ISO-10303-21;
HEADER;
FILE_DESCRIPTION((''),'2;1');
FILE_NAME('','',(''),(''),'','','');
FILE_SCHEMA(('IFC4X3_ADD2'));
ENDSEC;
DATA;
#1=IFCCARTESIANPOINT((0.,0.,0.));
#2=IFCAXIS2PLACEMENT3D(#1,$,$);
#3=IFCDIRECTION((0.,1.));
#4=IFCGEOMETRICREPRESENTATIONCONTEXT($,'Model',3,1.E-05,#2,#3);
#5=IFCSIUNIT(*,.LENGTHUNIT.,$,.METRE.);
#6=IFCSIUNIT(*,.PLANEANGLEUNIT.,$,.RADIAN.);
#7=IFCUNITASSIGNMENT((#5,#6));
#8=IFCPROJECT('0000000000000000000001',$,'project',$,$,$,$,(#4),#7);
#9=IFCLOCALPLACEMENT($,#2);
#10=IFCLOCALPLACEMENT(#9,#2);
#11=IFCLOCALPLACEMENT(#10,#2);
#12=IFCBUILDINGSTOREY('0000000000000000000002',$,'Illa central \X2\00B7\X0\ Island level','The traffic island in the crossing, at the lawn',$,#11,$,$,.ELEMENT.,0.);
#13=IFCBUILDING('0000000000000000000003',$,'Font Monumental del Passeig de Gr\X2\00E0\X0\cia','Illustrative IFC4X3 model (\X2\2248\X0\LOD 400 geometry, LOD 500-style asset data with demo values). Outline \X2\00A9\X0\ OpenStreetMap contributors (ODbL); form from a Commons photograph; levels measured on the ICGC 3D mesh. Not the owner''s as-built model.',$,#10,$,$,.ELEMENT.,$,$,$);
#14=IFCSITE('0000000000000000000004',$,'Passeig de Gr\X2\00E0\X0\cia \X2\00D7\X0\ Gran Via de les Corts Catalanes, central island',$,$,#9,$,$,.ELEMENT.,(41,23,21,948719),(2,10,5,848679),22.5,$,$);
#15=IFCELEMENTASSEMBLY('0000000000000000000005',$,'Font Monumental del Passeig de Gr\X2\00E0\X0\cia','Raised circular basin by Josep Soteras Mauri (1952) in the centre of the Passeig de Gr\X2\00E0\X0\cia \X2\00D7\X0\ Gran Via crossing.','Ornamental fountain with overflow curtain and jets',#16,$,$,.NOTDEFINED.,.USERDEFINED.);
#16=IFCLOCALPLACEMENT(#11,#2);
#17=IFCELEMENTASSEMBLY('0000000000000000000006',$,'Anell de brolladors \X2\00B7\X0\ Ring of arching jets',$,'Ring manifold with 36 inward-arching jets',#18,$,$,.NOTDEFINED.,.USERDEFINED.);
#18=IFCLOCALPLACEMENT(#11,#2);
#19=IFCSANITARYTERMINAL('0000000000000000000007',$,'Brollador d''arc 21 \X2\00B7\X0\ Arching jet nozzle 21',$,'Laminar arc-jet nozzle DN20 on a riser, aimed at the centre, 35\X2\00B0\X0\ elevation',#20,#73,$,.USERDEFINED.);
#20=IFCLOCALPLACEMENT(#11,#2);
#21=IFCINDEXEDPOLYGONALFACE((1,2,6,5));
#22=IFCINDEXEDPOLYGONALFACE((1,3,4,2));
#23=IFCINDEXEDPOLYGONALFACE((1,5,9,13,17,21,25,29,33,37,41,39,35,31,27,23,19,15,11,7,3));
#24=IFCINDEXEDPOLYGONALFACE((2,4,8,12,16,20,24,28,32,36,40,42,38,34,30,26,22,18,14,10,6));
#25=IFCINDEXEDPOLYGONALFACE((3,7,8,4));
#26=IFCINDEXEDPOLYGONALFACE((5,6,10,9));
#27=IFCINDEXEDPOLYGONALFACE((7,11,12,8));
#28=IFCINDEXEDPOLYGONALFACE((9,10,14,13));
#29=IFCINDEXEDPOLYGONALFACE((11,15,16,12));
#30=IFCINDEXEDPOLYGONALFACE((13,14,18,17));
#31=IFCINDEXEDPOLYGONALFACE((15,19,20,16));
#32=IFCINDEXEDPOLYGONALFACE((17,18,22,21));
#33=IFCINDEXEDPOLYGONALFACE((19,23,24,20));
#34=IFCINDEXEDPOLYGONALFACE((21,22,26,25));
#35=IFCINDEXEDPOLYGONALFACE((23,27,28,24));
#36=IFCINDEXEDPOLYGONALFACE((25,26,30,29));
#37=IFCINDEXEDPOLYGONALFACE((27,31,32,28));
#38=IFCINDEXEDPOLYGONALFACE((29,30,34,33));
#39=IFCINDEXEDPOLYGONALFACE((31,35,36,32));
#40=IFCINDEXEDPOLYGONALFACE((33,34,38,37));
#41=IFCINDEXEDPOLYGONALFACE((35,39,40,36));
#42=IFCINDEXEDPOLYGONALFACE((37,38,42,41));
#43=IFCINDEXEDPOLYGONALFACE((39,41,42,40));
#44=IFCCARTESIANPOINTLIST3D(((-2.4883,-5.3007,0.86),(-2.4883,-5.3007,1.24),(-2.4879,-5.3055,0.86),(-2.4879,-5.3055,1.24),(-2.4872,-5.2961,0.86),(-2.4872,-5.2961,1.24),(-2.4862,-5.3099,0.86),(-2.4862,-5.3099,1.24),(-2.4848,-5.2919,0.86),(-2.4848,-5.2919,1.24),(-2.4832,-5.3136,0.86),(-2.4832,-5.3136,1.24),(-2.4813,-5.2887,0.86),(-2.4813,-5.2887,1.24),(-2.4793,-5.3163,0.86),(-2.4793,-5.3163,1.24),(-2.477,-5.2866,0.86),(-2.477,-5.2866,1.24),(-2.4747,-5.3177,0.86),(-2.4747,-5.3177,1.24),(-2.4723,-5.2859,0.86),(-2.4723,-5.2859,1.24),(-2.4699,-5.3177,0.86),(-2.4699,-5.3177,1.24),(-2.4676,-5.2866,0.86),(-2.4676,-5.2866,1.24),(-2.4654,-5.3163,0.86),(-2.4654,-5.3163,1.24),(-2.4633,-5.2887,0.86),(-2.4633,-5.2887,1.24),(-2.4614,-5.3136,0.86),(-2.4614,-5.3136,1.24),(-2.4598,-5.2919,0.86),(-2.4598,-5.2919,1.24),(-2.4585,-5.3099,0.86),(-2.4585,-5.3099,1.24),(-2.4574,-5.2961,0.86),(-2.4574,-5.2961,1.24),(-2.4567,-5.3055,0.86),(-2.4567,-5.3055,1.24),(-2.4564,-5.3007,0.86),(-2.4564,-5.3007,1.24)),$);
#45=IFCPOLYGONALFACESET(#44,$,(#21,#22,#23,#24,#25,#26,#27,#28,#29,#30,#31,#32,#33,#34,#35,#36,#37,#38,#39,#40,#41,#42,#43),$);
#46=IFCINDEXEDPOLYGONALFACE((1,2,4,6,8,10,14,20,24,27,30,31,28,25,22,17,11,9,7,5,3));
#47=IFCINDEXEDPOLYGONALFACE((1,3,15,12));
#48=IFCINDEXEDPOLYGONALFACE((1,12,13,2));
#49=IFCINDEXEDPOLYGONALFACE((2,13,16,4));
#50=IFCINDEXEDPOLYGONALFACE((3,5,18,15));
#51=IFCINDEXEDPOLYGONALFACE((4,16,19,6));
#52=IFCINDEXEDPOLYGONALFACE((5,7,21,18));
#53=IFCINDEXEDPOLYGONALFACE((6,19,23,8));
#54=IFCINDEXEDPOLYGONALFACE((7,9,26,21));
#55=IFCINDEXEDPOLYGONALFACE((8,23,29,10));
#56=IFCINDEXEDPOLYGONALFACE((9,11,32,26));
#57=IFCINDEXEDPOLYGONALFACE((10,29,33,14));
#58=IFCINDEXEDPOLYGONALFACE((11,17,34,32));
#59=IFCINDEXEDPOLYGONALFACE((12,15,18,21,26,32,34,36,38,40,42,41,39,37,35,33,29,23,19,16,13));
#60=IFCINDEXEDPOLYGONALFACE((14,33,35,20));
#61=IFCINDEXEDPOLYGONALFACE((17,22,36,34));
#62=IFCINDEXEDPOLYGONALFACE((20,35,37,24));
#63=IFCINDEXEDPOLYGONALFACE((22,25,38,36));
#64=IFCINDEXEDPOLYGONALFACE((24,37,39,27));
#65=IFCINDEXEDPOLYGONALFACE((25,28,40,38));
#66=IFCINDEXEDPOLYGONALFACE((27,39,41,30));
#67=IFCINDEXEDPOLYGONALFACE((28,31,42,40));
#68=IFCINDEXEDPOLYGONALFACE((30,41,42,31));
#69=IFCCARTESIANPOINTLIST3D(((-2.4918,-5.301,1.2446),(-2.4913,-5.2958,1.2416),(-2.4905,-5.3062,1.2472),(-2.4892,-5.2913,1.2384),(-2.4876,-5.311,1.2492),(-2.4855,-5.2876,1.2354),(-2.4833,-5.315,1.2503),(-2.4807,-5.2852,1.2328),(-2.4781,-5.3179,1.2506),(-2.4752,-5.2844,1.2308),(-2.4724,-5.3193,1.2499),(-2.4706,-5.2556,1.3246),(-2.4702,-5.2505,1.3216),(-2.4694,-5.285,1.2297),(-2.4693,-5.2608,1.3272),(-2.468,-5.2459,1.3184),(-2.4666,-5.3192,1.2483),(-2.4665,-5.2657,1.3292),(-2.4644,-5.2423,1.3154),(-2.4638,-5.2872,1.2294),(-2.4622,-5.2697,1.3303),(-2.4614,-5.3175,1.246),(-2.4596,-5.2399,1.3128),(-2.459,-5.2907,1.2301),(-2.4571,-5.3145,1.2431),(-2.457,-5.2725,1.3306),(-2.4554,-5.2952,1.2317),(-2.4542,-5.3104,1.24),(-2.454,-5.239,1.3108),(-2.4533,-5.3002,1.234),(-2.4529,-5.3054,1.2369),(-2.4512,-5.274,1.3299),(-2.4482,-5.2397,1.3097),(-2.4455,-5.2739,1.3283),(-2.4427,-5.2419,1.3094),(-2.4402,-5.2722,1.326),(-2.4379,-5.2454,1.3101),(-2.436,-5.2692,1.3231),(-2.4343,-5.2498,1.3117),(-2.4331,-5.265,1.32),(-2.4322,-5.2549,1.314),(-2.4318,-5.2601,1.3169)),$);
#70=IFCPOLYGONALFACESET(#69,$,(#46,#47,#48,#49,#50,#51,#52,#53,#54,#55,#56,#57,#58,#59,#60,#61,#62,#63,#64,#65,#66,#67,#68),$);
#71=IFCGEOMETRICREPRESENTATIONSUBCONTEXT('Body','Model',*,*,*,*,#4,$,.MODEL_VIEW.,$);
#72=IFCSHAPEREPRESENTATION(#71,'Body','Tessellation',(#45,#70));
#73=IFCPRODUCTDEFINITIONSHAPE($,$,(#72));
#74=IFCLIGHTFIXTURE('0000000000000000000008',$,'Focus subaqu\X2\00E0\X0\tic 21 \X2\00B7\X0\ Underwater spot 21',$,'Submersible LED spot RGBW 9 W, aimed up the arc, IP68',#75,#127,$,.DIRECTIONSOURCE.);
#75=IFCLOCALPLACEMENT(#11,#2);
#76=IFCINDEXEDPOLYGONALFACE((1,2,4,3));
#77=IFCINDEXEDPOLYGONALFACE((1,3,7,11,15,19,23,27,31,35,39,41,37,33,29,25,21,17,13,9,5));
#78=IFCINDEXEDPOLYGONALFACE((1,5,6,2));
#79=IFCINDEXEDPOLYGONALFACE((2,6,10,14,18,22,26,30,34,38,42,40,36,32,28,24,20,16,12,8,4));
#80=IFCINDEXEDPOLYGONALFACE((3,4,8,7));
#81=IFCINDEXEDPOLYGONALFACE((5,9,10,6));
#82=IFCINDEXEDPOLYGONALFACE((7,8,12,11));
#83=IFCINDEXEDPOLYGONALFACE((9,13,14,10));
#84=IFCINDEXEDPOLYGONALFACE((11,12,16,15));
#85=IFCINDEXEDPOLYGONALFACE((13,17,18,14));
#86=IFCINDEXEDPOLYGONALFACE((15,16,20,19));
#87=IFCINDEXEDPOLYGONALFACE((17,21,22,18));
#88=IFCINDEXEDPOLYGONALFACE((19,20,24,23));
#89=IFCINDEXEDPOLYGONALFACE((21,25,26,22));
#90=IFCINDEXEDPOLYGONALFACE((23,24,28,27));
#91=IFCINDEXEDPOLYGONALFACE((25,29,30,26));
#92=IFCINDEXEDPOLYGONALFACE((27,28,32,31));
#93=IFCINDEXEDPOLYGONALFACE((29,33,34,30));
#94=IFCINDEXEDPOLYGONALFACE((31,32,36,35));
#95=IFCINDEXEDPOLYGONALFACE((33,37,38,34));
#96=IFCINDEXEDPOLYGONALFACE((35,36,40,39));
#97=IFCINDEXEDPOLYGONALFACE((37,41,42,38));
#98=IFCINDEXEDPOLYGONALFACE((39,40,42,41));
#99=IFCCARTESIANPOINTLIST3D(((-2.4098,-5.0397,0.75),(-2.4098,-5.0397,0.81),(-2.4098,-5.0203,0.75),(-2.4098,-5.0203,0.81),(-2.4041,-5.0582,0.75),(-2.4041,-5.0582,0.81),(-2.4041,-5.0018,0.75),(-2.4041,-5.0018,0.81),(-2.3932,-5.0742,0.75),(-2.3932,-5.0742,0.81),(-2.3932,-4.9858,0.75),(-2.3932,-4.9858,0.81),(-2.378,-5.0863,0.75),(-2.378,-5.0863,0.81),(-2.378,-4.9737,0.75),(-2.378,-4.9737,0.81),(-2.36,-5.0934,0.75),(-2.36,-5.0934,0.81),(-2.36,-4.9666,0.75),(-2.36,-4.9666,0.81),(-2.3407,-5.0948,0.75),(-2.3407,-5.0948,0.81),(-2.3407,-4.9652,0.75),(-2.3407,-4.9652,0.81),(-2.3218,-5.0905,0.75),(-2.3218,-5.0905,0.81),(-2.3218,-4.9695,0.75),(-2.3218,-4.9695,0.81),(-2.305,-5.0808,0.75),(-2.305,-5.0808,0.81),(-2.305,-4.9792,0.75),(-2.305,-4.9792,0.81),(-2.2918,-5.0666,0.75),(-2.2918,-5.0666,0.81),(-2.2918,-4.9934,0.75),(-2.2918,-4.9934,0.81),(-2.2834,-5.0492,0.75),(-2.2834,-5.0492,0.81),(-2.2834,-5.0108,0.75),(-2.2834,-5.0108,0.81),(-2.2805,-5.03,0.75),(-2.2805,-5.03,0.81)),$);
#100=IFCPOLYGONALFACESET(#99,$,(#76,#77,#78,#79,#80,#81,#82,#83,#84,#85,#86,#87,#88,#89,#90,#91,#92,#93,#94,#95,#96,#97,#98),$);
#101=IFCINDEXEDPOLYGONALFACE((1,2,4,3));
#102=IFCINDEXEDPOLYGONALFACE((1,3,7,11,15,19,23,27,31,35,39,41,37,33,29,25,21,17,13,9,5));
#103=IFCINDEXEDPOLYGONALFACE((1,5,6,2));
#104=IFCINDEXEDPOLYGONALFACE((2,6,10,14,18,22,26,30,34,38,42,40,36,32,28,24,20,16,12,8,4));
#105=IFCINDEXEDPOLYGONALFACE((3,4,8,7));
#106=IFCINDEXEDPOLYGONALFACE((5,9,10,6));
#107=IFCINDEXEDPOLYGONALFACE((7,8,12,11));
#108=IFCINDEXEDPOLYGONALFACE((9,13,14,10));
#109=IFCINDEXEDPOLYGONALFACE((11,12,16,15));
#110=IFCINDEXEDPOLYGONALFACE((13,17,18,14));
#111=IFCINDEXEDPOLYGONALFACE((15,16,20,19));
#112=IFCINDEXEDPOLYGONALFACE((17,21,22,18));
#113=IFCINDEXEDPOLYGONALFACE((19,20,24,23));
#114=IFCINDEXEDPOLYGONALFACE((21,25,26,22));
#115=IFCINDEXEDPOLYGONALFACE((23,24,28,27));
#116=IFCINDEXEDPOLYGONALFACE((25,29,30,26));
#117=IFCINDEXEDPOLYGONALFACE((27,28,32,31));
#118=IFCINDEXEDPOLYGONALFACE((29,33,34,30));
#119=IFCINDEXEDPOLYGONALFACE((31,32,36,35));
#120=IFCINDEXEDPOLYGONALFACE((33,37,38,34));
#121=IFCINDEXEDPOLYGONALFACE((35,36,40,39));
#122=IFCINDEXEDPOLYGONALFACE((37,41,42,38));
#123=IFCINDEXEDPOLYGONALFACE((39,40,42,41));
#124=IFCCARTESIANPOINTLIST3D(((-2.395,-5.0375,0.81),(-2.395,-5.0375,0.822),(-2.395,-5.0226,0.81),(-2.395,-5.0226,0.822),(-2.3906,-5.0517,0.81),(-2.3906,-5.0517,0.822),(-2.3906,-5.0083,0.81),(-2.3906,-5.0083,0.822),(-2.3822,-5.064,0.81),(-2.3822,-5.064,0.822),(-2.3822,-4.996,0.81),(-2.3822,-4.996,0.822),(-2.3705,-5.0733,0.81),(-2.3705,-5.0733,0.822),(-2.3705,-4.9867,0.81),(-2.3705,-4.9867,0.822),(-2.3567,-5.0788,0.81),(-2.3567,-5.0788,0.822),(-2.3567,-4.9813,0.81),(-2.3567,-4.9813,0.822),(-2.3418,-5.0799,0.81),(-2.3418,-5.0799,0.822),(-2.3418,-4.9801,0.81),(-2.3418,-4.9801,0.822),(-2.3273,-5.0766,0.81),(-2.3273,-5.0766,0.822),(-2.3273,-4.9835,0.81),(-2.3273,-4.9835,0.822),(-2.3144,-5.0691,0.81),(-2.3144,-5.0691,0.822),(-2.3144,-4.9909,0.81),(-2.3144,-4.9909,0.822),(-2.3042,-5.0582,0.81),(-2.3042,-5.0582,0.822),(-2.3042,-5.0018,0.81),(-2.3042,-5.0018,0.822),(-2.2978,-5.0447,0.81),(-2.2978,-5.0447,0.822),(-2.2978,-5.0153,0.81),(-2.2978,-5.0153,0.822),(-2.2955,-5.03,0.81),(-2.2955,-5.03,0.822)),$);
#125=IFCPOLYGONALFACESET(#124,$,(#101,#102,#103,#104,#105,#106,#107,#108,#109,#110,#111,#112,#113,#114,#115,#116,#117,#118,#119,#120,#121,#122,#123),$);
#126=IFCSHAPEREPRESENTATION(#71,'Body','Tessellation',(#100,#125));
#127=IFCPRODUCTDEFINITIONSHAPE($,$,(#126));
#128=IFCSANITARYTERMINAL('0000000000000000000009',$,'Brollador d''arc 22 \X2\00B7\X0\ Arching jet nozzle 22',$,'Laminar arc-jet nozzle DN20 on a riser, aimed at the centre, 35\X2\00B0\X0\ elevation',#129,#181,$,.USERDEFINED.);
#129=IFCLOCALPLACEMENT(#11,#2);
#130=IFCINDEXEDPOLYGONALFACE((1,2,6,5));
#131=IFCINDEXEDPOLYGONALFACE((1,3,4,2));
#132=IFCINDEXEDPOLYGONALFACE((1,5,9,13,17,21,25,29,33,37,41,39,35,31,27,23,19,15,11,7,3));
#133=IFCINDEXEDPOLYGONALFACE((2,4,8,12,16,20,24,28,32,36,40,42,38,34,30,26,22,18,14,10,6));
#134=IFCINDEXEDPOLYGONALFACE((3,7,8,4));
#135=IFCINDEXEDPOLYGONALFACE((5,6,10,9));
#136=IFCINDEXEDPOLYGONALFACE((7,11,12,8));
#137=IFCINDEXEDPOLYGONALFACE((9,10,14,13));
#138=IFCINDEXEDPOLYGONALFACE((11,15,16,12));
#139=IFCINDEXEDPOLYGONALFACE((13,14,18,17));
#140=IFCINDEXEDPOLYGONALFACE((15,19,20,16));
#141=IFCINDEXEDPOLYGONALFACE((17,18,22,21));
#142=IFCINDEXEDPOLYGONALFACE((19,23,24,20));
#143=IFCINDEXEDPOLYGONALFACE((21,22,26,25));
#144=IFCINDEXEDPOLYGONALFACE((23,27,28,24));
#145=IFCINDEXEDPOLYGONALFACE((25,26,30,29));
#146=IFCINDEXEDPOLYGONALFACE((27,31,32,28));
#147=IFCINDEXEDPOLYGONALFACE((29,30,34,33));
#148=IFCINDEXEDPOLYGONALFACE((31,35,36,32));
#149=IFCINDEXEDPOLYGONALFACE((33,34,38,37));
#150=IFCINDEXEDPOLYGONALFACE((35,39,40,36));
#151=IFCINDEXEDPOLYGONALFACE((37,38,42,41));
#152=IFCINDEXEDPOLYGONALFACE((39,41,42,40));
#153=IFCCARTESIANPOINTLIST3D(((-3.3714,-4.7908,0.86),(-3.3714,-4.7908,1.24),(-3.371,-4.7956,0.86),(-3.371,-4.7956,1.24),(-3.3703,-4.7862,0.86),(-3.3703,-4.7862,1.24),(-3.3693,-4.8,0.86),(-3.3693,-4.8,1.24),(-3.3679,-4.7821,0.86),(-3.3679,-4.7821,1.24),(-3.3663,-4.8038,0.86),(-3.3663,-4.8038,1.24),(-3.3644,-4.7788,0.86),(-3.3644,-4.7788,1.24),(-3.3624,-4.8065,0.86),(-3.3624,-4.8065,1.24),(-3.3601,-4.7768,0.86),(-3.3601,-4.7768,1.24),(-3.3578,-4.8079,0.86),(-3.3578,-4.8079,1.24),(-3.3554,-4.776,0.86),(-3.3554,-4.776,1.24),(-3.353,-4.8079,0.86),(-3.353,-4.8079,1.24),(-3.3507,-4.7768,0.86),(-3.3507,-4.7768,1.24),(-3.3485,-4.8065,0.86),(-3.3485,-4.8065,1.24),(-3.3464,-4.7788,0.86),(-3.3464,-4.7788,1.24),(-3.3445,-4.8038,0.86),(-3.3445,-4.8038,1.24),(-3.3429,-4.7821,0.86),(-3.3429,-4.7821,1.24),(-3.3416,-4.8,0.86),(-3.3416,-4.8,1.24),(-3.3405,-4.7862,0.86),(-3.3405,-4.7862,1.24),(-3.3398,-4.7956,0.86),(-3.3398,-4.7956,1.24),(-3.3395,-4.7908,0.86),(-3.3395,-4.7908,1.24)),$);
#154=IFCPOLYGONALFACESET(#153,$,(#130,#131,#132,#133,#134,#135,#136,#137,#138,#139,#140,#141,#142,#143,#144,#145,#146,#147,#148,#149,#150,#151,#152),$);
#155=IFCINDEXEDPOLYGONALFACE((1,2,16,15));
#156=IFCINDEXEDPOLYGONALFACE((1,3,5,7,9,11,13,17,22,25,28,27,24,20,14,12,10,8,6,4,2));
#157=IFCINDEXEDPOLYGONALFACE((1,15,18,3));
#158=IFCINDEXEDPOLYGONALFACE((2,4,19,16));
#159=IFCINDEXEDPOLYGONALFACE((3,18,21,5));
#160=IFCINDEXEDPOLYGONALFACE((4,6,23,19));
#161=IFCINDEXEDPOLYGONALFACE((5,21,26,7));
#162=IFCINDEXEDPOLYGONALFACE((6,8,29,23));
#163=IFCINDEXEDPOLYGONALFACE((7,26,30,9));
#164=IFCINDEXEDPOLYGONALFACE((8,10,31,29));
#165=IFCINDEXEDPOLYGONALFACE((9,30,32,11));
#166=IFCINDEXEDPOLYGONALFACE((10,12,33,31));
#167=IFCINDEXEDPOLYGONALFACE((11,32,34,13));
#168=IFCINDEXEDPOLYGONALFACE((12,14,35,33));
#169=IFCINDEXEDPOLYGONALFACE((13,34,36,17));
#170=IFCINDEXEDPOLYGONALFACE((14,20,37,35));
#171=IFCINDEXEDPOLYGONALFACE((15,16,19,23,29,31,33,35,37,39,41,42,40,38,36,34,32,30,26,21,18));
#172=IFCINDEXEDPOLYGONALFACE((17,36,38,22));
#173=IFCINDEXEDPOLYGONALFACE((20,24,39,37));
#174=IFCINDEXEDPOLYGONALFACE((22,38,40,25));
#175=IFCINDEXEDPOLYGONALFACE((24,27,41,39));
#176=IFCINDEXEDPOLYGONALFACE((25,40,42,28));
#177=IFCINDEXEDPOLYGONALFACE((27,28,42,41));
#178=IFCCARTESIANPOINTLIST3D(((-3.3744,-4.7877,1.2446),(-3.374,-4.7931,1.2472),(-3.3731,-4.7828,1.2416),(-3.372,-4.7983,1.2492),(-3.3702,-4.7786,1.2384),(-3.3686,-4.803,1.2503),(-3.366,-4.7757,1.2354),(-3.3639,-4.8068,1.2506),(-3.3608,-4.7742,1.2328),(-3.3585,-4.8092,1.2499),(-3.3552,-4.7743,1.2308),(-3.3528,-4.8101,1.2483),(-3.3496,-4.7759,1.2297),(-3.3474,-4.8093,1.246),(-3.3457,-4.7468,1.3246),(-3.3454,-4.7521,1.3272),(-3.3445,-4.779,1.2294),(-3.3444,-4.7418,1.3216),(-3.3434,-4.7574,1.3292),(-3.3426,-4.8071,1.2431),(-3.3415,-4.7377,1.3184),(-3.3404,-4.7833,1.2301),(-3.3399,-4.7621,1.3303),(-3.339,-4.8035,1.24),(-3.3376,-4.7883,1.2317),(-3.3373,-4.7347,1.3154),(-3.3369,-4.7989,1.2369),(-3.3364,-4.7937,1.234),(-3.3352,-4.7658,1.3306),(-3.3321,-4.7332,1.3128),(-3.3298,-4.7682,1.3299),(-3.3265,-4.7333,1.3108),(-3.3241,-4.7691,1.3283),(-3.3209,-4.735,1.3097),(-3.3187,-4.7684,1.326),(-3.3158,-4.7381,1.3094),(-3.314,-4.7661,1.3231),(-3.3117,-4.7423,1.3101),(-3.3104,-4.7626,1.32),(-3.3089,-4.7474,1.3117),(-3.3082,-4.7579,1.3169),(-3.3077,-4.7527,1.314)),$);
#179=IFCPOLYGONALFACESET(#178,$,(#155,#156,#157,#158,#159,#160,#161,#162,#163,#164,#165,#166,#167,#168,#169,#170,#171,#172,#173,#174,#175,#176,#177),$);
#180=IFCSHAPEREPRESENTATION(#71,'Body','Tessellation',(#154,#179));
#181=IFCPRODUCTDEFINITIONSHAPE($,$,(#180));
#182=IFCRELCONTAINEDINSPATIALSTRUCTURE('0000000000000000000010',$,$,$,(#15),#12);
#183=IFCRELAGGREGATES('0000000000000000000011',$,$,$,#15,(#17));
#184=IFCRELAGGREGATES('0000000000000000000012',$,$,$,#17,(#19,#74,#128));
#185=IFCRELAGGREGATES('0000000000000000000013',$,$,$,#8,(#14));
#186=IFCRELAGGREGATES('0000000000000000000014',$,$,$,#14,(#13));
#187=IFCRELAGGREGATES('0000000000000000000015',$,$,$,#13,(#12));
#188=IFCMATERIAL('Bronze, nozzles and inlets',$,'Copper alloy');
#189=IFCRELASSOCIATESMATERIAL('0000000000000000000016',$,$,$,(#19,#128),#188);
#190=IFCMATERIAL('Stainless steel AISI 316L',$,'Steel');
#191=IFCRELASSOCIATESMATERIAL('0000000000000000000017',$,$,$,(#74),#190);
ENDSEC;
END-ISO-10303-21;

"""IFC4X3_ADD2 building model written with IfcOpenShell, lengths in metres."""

from ifc_helpers import new_model, si_unit, direction, frame, origin, origin_2d_with_axis, place, context, subcontext, project, spatial, circle, extrude, material, element, aggregate, save


model = new_model("IFC4X3_ADD2")

# Units and contexts
model_context = context("Model", 3, precision=1e-05, world=origin(), true_north=direction((0.0, 1.0)))
body_context = subcontext(model_context, "Body", "Model", "MODEL_VIEW")
ifc_project = project(units=[si_unit("LENGTHUNIT", "METRE"), si_unit("PLANEANGLEUNIT", "RADIAN")], contexts=[model_context])

# Site, building, storey
site_placement = place(None, origin())
site = spatial("IfcSite", under=ifc_project, at=site_placement, Name="Passeig de Gràcia × Gran Via de les Corts Catalanes, central island", CompositionType="ELEMENT", RefLatitude=(41, 23, 21, 948719), RefLongitude=(2, 10, 5, 848679), RefElevation=22.5)
building_placement = place(site_placement, origin())
building = spatial("IfcBuilding", under=site, at=building_placement, Name="Font Monumental del Passeig de Gràcia", Description="Illustrative IFC4X3 model (≈LOD 400 geometry, LOD 500-style asset data with demo values). Outline © OpenStreetMap contributors (ODbL); form from a Commons photograph; levels measured on the ICGC 3D mesh. Not the owner's as-built model.", CompositionType="ELEMENT")
storey_placement = place(building_placement, origin())
storey = spatial("IfcBuildingStorey", under=building, at=storey_placement, Name="Illa central · Island level", Description="The traffic island in the crossing, at the lawn", CompositionType="ELEMENT", Elevation=0.0)

# Element assemblies, sanitary terminals, light fixture
assembly_1_placement = place(building_placement, origin())
assembly_1 = element("IfcElementAssembly", 1, at=assembly_1_placement, inside=storey, Name="Font Monumental del Passeig de Gràcia", Description="Raised circular basin by Josep Soteras Mauri (1952) in the centre of the Passeig de Gràcia × Gran Via crossing.", ObjectType="Ornamental fountain with overflow curtain and jets", AssemblyPlace="NOTDEFINED", PredefinedType="USERDEFINED")
assembly_2_placement = place(building_placement, origin())
assembly_2 = element("IfcElementAssembly", 2, at=assembly_2_placement, Name="Anell de brolladors · Ring of arching jets", ObjectType="Ring manifold with 36 inward-arching jets", AssemblyPlace="NOTDEFINED", PredefinedType="USERDEFINED")
aggregate(assembly_1, [assembly_2])
ifc_material_1 = material(Name="Stainless steel AISI 316L", Category="Steel")
ifc_material_2 = material(Name="Bronze, nozzles and inlets", Category="Copper alloy")
sanitary_terminal_1_placement = place(building_placement, origin())
sanitary_terminal_1 = element("IfcSanitaryTerminal", 3, at=sanitary_terminal_1_placement, material=ifc_material_2, Name="Brollador d'arc 21 · Arching jet nozzle 21", ObjectType="Laminar arc-jet nozzle DN20 on a riser, aimed at the centre, 35° elevation", PredefinedType="USERDEFINED", context=body_context, shape_type="SweptSolid", body=[
    extrude(circle(Radius=0.016, at=origin_2d_with_axis()), frame((-2.4723, -5.3019, 0.86), z_axis=(0.0, 0.0, 1.0), x_axis=(0.0, 1.0, 0.0)), (0.0, 0.0, 1.0), 0.38),
    extrude(circle(Radius=0.02, at=origin_2d_with_axis()), frame((-2.4723, -5.3019, 1.24), z_axis=(0.223987, 0.480342, 0.847998), x_axis=(0.906308, -0.422618, 0.0)), (0.0, 0.0, 1.0), 0.0943),
])
light_fixture_1_placement = place(building_placement, origin())
light_fixture_1 = element("IfcLightFixture", 4, at=light_fixture_1_placement, material=ifc_material_1, Name="Focus subaquàtic 21 · Underwater spot 21", ObjectType="Submersible LED spot RGBW 9 W, aimed up the arc, IP68", PredefinedType="DIRECTIONSOURCE", context=body_context, shape_type="SweptSolid", body=[
    extrude(circle(Radius=0.065, at=origin_2d_with_axis()), frame((-2.3455, -5.03, 0.75)), (0.0, 0.0, 1.0), 0.06),
    extrude(circle(Radius=0.05, at=origin_2d_with_axis()), frame((-2.3455, -5.03, 0.81)), (0.0, 0.0, 1.0), 0.012),
])
sanitary_terminal_2_placement = place(building_placement, origin())
sanitary_terminal_2 = element("IfcSanitaryTerminal", 5, at=sanitary_terminal_2_placement, material=ifc_material_2, Name="Brollador d'arc 22 · Arching jet nozzle 22", ObjectType="Laminar arc-jet nozzle DN20 on a riser, aimed at the centre, 35° elevation", PredefinedType="USERDEFINED", context=body_context, shape_type="SweptSolid", body=[
    extrude(circle(Radius=0.016, at=origin_2d_with_axis()), frame((-3.3554, -4.792, 0.86), z_axis=(0.0, 0.0, 1.0), x_axis=(0.0, 1.0, 0.0)), (0.0, 0.0, 1.0), 0.38),
    extrude(circle(Radius=0.02, at=origin_2d_with_axis()), frame((-3.3554, -4.792, 1.24), z_axis=(0.303995, 0.43415, 0.847998), x_axis=(0.819152, -0.573576, 0.0)), (0.0, 0.0, 1.0), 0.0943),
])
aggregate(assembly_2, [sanitary_terminal_1, light_fixture_1, sanitary_terminal_2])

save(model, "model.ifc")
